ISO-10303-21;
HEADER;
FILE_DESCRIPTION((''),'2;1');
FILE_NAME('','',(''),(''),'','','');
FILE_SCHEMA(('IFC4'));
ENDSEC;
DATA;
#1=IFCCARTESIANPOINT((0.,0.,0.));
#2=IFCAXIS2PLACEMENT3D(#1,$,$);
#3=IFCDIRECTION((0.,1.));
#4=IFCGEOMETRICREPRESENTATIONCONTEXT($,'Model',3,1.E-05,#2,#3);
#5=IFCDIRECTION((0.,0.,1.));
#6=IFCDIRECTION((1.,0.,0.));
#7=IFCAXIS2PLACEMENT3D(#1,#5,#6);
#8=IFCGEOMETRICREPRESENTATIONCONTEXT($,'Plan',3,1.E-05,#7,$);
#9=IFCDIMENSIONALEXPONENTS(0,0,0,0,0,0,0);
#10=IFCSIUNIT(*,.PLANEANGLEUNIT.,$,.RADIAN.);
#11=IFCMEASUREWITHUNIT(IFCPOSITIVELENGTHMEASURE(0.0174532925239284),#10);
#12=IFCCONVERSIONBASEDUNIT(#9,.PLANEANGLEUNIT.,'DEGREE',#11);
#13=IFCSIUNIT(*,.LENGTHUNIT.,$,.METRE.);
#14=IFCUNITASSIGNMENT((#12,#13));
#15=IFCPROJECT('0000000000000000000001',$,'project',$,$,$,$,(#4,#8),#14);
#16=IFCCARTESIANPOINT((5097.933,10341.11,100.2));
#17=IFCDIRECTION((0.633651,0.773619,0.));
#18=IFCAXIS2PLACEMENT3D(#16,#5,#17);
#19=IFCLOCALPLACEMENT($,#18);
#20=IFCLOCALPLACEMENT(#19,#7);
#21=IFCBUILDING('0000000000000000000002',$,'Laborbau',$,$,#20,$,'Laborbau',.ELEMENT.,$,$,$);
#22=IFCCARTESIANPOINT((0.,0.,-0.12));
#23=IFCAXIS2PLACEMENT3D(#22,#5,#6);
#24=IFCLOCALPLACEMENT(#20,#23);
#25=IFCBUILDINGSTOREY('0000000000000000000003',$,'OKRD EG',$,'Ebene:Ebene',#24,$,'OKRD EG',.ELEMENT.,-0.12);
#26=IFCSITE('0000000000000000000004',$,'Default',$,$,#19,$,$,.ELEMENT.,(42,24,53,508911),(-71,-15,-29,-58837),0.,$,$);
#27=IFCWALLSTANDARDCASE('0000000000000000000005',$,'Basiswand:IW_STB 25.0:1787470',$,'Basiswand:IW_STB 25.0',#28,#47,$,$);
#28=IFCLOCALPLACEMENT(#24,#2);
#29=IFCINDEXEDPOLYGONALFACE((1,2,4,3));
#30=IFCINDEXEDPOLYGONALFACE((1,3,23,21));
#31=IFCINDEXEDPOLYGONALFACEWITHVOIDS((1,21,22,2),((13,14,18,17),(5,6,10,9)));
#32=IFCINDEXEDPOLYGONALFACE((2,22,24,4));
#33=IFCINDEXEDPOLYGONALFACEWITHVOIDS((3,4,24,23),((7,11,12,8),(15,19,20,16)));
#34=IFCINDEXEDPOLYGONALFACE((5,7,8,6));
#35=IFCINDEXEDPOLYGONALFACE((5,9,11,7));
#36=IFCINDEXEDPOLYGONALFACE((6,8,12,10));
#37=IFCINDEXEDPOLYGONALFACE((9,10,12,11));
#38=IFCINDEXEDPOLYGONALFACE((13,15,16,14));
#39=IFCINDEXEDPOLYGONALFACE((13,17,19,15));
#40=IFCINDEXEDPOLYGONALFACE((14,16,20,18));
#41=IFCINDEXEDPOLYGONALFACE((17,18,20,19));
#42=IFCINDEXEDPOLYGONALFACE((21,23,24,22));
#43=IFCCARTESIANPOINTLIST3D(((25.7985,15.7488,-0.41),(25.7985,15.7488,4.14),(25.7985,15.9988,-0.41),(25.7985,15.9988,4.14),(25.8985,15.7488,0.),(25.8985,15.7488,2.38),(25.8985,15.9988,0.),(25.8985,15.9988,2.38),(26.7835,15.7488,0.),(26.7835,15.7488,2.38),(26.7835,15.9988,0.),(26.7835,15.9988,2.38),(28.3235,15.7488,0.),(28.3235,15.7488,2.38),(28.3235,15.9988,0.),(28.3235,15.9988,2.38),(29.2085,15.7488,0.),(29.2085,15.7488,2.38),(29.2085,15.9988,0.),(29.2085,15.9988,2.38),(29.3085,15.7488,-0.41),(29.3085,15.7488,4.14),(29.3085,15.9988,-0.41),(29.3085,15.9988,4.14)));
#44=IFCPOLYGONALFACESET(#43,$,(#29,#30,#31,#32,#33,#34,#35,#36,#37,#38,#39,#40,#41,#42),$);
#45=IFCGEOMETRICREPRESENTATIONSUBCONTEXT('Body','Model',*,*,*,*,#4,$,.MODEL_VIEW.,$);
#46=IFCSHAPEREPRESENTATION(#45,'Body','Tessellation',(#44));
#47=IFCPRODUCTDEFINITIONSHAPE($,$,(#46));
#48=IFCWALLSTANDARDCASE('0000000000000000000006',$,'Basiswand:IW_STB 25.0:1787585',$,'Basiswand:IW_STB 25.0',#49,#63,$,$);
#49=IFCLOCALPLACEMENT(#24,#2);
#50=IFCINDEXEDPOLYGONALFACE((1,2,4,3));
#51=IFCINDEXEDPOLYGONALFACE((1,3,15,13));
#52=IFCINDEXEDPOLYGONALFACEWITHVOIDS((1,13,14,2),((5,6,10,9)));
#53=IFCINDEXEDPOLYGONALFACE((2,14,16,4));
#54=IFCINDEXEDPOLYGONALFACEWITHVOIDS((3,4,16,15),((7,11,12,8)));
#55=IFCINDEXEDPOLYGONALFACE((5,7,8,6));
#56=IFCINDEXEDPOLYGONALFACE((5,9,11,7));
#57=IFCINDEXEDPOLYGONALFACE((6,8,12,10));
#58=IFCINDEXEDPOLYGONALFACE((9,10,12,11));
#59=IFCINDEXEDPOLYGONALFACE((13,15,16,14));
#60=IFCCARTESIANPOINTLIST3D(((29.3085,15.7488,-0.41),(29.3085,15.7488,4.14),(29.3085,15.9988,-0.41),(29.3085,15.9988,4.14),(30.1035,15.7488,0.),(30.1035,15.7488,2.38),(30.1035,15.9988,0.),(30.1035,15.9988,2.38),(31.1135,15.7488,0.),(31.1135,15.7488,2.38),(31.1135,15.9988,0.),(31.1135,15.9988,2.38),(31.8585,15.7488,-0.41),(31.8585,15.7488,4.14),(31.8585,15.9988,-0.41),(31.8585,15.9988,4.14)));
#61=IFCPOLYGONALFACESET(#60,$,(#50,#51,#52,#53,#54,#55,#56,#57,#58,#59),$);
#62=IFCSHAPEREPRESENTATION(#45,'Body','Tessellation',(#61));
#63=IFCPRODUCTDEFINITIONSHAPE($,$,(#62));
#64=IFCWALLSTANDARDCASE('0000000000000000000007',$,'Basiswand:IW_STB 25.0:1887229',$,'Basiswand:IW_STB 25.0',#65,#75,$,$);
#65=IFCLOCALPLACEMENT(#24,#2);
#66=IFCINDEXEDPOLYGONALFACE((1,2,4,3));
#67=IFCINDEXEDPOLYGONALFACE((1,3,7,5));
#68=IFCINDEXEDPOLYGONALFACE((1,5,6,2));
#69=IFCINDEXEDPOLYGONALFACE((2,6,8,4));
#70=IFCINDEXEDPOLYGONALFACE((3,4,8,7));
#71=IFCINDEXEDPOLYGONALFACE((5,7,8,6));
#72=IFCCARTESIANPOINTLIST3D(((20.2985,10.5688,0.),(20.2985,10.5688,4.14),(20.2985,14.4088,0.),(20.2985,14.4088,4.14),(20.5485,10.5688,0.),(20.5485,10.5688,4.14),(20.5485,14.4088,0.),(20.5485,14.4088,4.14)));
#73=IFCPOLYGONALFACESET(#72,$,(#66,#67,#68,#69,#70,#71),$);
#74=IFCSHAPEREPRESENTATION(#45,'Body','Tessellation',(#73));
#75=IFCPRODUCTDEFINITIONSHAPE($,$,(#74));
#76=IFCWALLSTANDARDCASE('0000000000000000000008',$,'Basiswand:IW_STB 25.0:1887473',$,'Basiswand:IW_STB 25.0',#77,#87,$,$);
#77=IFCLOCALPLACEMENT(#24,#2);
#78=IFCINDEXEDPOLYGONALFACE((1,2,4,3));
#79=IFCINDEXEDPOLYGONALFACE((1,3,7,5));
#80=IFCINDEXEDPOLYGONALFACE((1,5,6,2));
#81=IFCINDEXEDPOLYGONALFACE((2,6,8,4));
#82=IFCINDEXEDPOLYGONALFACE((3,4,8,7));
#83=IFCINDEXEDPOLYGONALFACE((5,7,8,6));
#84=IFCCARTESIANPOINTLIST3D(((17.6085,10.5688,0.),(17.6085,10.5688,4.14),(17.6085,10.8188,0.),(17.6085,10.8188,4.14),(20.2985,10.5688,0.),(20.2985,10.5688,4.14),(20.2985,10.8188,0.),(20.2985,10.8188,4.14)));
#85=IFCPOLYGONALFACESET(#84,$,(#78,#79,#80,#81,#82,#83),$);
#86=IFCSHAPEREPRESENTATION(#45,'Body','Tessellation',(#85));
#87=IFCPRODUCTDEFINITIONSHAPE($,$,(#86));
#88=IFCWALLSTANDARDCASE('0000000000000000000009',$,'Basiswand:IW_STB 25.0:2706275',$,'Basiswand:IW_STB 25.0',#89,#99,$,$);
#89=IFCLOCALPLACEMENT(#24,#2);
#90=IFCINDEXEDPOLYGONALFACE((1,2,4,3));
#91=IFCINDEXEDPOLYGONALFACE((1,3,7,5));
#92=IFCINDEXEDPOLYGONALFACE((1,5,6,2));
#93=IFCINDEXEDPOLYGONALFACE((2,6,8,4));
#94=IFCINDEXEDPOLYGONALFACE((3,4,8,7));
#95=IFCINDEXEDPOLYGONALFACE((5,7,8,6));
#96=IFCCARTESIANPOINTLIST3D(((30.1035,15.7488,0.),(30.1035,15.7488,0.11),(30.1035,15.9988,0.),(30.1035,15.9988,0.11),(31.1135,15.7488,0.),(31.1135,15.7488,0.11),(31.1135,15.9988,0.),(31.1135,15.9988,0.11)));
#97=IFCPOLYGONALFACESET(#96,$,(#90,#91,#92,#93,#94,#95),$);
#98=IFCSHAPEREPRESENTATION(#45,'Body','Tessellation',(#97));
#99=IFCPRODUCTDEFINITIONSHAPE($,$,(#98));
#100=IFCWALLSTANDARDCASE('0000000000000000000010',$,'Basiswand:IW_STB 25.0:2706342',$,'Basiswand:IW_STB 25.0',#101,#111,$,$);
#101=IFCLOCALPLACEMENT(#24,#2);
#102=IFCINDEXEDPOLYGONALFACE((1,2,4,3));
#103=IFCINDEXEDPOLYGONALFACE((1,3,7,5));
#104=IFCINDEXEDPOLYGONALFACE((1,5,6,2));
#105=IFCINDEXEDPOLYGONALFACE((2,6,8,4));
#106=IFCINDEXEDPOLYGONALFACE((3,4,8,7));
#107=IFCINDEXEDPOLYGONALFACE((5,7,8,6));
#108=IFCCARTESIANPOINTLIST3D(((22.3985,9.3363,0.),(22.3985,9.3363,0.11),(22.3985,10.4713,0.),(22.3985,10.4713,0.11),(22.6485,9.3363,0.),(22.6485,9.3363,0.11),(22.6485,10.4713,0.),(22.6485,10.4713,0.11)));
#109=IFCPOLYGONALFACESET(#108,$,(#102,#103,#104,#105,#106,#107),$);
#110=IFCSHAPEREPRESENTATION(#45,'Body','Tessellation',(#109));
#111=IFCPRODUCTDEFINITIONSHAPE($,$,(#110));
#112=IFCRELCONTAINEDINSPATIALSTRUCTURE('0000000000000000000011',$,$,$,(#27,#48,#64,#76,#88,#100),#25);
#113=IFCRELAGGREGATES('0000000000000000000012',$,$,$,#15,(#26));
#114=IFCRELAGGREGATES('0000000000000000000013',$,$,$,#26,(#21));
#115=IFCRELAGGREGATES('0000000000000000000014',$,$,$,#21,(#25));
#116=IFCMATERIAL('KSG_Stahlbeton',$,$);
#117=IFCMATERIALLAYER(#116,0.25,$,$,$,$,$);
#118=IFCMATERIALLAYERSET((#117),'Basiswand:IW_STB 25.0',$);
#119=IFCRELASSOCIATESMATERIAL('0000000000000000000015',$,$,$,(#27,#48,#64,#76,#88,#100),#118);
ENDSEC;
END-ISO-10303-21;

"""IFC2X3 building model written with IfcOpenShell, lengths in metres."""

from ifc_helpers import new_model, entity, si_unit, converted_unit, direction, frame, frame_2d, origin, origin_with_axes, place, context, subcontext, project, spatial, rectangle, extrude, clip, halfspace, material, layer, layer_set, layer_usage, element, save


model = new_model("IFC2X3")

# Units and contexts
model_context = context("Model", 3, precision=1e-05, world=origin(), true_north=direction((0.0, 1.0)))
plan_context = context("Plan", 3, precision=1e-05, world=origin_with_axes())
body_context = subcontext(model_context, "Body", "Model", "MODEL_VIEW")
ifc_project = project(units=[converted_unit("PLANEANGLEUNIT", "DEGREE", entity("IfcPositiveLengthMeasure", 0.0174532925239284), si_unit("PLANEANGLEUNIT", "RADIAN"), dimensions=[0, 0, 0, 0, 0, 0, 0]), si_unit("LENGTHUNIT", "METRE")], contexts=[model_context, plan_context])

# Site, building, storey
site_placement = place(None, frame((5097.933, 10341.11, 100.2), z_axis=(0.0, 0.0, 1.0), x_axis=(0.633651, 0.773619, 0.0)))
site = spatial("IfcSite", under=ifc_project, at=site_placement, Name="Default", CompositionType="ELEMENT", RefLatitude=(42, 24, 53, 508911), RefLongitude=(-71, -15, -29, -58837), RefElevation=0.0)
building_placement = place(site_placement, origin_with_axes())
building = spatial("IfcBuilding", under=site, at=building_placement, Name="Laborbau", LongName="Laborbau", CompositionType="ELEMENT")
storey_placement = place(building_placement, frame((0.0, 0.0, -0.12), z_axis=(0.0, 0.0, 1.0), x_axis=(1.0, 0.0, 0.0)))
storey = spatial("IfcBuildingStorey", under=building, at=storey_placement, Name="OKRD EG", ObjectType="Ebene:Ebene", LongName="OKRD EG", CompositionType="ELEMENT", Elevation=-0.12)

# Shared definitions
ifc_material_1 = material(Name="KSG_Stahlbeton")
ifc_layer_1 = layer(ifc_material_1, 0.25)
ifc_layer_set_1 = layer_set([ifc_layer_1], Name="Basiswand:IW_STB 25.0")

# Walls, openings
ifc_layer_usage_1 = layer_usage(ifc_layer_set_1, "AXIS2", "NEGATIVE", 0.125)
wall_1_placement = place(storey_placement, frame((25.7985, 15.8738, -0.41), z_axis=(0.0, 0.0, 1.0), x_axis=(1.0, 0.0, 0.0)))
wall_1 = element("IfcWallStandardCase", 1, at=wall_1_placement, inside=storey, material=ifc_layer_usage_1, Name="Basiswand:IW_STB 25.0:1787470", ObjectType="Basiswand:IW_STB 25.0", context=body_context, shape_type="SweptSolid", body=[
    extrude(rectangle(XDim=3.51, YDim=0.25, at=frame_2d((1.755, 0.0), x_axis=(-1.0, 0.0))), origin(), (0.0, 0.0, 1.0), 4.55),
])
opening_1_placement = place(wall_1_placement, frame((0.1, -0.125, 0.41), z_axis=(0.0, 0.0, 1.0), x_axis=(1.0, 0.0, 0.0)))
element("IfcOpeningElement", 2, at=opening_1_placement, cuts=wall_1, ObjectType="Opening", context=body_context, shape_type="SweptSolid", body=[
    extrude(rectangle(XDim=2.38, YDim=0.885, at=frame_2d((1.19, 0.4425), x_axis=(1.0, 0.0))), frame((0.0, 0.0, 0.0), z_axis=(0.0, 1.0, 0.0), x_axis=(0.0, 0.0, 1.0)), (0.0, 0.0, 1.0), 0.25),
])
opening_2_placement = place(wall_1_placement, frame((-25.7985, -15.8738, 0.41), z_axis=(0.0, 0.0, 1.0), x_axis=(1.0, 0.0, 0.0)))
element("IfcOpeningElement", 3, at=opening_2_placement, cuts=wall_1, ObjectType="Opening", context=body_context, shape_type="SweptSolid", body=[
    extrude(rectangle(XDim=2.38, YDim=0.885, at=frame_2d((0.0, 0.0), x_axis=(0.0, 1.0))), frame((26.341, 14.2248, 1.19), z_axis=(0.0, 1.0, 0.0), x_axis=(-1.0, 0.0, 0.0)), (0.0, 0.0, 1.0), 3.048),
])
opening_3_placement = place(wall_1_placement, frame((2.525, -0.125, 0.41), z_axis=(0.0, 0.0, 1.0), x_axis=(1.0, 0.0, 0.0)))
element("IfcOpeningElement", 4, at=opening_3_placement, cuts=wall_1, ObjectType="Opening", context=body_context, shape_type="SweptSolid", body=[
    extrude(rectangle(XDim=2.38, YDim=0.885, at=frame_2d((1.19, 0.4425), x_axis=(1.0, 0.0))), frame((0.0, 0.0, 0.0), z_axis=(0.0, 1.0, 0.0), x_axis=(0.0, 0.0, 1.0)), (0.0, 0.0, 1.0), 0.25),
])
opening_4_placement = place(wall_1_placement, frame((-25.7985, -15.8738, 0.41), z_axis=(0.0, 0.0, 1.0), x_axis=(1.0, 0.0, 0.0)))
element("IfcOpeningElement", 5, at=opening_4_placement, cuts=wall_1, ObjectType="Opening", context=body_context, shape_type="SweptSolid", body=[
    extrude(rectangle(XDim=2.38, YDim=0.885, at=frame_2d((0.0, 0.0), x_axis=(1.0, 0.0))), frame((28.766, 14.2248, 1.19), z_axis=(0.0, 1.0, 0.0), x_axis=(0.0, 0.0, 1.0)), (0.0, 0.0, 1.0), 3.048),
])
ifc_layer_usage_2 = layer_usage(ifc_layer_set_1, "AXIS2", "NEGATIVE", 0.125)
wall_2_placement = place(storey_placement, frame((29.3085, 15.8738, -0.41), z_axis=(0.0, 0.0, 1.0), x_axis=(1.0, 0.0, 0.0)))
wall_2 = element("IfcWallStandardCase", 6, at=wall_2_placement, inside=storey, material=ifc_layer_usage_2, Name="Basiswand:IW_STB 25.0:1787585", ObjectType="Basiswand:IW_STB 25.0", context=body_context, shape_type="SweptSolid", body=[
    extrude(rectangle(XDim=2.55, YDim=0.25, at=frame_2d((1.275, 0.0), x_axis=(-1.0, 0.0))), origin(), (0.0, 0.0, 1.0), 4.55),
])
opening_5_placement = place(wall_2_placement, frame((0.795, -0.125, 0.41), z_axis=(0.0, 0.0, 1.0), x_axis=(1.0, 0.0, 0.0)))
element("IfcOpeningElement", 7, at=opening_5_placement, cuts=wall_2, ObjectType="Opening", context=body_context, shape_type="SweptSolid", body=[
    extrude(rectangle(XDim=2.38, YDim=1.01, at=frame_2d((1.19, 0.505), x_axis=(1.0, 0.0))), frame((0.0, 0.0, 0.0), z_axis=(0.0, 1.0, 0.0), x_axis=(0.0, 0.0, 1.0)), (0.0, 0.0, 1.0), 0.25),
])
opening_6_placement = place(wall_2_placement, frame((-29.3085, -15.8738, 0.41), z_axis=(0.0, 0.0, 1.0), x_axis=(1.0, 0.0, 0.0)))
element("IfcOpeningElement", 8, at=opening_6_placement, cuts=wall_2, ObjectType="Opening", context=body_context, shape_type="SweptSolid", body=[
    extrude(rectangle(XDim=2.38, YDim=1.01, at=frame_2d((0.0, 0.0), x_axis=(1.0, 0.0))), frame((30.6085, 14.2248, 1.19), z_axis=(0.0, 1.0, 0.0), x_axis=(0.0, 0.0, 1.0)), (0.0, 0.0, 1.0), 3.048),
])

# Walls
ifc_layer_usage_3 = layer_usage(ifc_layer_set_1, "AXIS2", "POSITIVE", -0.125)
wall_3_placement = place(storey_placement, frame((20.4235, 10.5688, 0.0), z_axis=(0.0, 0.0, 1.0), x_axis=(0.0, 1.0, 0.0)))
element("IfcWallStandardCase", 9, at=wall_3_placement, inside=storey, material=ifc_layer_usage_3, Name="Basiswand:IW_STB 25.0:1887229", ObjectType="Basiswand:IW_STB 25.0", context=body_context, shape_type="Clipping", body=[
    clip(extrude(rectangle(XDim=3.84, YDim=0.25, at=frame_2d((1.92, 0.0), x_axis=(-1.0, 0.0))), origin(), (0.0, 0.0, 1.0), 4.14), halfspace(frame((0.0, 0.0, -1.58)), True)),
])
ifc_layer_usage_4 = layer_usage(ifc_layer_set_1, "AXIS2", "NEGATIVE", 0.125)
wall_4_placement = place(storey_placement, frame((17.6085, 10.6938, 0.0), z_axis=(0.0, 0.0, 1.0), x_axis=(1.0, 0.0, 0.0)))
element("IfcWallStandardCase", 10, at=wall_4_placement, inside=storey, material=ifc_layer_usage_4, Name="Basiswand:IW_STB 25.0:1887473", ObjectType="Basiswand:IW_STB 25.0", context=body_context, shape_type="Clipping", body=[
    clip(extrude(rectangle(XDim=2.69, YDim=0.25, at=frame_2d((1.345, 0.0), x_axis=(-1.0, 0.0))), origin(), (0.0, 0.0, 1.0), 4.14), halfspace(frame((0.0, 0.0, -1.58)), True)),
])
ifc_layer_usage_5 = layer_usage(ifc_layer_set_1, "AXIS2", "NEGATIVE", 0.125)
wall_5_placement = place(storey_placement, frame((30.1035, 15.8738, 0.0), z_axis=(0.0, 0.0, 1.0), x_axis=(1.0, 0.0, 0.0)))
element("IfcWallStandardCase", 11, at=wall_5_placement, inside=storey, material=ifc_layer_usage_5, Name="Basiswand:IW_STB 25.0:2706275", ObjectType="Basiswand:IW_STB 25.0", context=body_context, shape_type="SweptSolid", body=[
    extrude(rectangle(XDim=1.01, YDim=0.25, at=frame_2d((0.505, 0.0), x_axis=(-1.0, 0.0))), origin(), (0.0, 0.0, 1.0), 0.11),
])
ifc_layer_usage_6 = layer_usage(ifc_layer_set_1, "AXIS2", "NEGATIVE", 0.125)
wall_6_placement = place(storey_placement, frame((22.5235, 10.4713, 0.0), z_axis=(0.0, 0.0, 1.0), x_axis=(0.0, -1.0, 0.0)))
element("IfcWallStandardCase", 12, at=wall_6_placement, inside=storey, material=ifc_layer_usage_6, Name="Basiswand:IW_STB 25.0:2706342", ObjectType="Basiswand:IW_STB 25.0", context=body_context, shape_type="SweptSolid", body=[
    extrude(rectangle(XDim=1.135, YDim=0.25, at=frame_2d((0.5675, 0.0), x_axis=(-1.0, 0.0))), origin(), (0.0, 0.0, 1.0), 0.11),
])

save(model, "model.ifc")
